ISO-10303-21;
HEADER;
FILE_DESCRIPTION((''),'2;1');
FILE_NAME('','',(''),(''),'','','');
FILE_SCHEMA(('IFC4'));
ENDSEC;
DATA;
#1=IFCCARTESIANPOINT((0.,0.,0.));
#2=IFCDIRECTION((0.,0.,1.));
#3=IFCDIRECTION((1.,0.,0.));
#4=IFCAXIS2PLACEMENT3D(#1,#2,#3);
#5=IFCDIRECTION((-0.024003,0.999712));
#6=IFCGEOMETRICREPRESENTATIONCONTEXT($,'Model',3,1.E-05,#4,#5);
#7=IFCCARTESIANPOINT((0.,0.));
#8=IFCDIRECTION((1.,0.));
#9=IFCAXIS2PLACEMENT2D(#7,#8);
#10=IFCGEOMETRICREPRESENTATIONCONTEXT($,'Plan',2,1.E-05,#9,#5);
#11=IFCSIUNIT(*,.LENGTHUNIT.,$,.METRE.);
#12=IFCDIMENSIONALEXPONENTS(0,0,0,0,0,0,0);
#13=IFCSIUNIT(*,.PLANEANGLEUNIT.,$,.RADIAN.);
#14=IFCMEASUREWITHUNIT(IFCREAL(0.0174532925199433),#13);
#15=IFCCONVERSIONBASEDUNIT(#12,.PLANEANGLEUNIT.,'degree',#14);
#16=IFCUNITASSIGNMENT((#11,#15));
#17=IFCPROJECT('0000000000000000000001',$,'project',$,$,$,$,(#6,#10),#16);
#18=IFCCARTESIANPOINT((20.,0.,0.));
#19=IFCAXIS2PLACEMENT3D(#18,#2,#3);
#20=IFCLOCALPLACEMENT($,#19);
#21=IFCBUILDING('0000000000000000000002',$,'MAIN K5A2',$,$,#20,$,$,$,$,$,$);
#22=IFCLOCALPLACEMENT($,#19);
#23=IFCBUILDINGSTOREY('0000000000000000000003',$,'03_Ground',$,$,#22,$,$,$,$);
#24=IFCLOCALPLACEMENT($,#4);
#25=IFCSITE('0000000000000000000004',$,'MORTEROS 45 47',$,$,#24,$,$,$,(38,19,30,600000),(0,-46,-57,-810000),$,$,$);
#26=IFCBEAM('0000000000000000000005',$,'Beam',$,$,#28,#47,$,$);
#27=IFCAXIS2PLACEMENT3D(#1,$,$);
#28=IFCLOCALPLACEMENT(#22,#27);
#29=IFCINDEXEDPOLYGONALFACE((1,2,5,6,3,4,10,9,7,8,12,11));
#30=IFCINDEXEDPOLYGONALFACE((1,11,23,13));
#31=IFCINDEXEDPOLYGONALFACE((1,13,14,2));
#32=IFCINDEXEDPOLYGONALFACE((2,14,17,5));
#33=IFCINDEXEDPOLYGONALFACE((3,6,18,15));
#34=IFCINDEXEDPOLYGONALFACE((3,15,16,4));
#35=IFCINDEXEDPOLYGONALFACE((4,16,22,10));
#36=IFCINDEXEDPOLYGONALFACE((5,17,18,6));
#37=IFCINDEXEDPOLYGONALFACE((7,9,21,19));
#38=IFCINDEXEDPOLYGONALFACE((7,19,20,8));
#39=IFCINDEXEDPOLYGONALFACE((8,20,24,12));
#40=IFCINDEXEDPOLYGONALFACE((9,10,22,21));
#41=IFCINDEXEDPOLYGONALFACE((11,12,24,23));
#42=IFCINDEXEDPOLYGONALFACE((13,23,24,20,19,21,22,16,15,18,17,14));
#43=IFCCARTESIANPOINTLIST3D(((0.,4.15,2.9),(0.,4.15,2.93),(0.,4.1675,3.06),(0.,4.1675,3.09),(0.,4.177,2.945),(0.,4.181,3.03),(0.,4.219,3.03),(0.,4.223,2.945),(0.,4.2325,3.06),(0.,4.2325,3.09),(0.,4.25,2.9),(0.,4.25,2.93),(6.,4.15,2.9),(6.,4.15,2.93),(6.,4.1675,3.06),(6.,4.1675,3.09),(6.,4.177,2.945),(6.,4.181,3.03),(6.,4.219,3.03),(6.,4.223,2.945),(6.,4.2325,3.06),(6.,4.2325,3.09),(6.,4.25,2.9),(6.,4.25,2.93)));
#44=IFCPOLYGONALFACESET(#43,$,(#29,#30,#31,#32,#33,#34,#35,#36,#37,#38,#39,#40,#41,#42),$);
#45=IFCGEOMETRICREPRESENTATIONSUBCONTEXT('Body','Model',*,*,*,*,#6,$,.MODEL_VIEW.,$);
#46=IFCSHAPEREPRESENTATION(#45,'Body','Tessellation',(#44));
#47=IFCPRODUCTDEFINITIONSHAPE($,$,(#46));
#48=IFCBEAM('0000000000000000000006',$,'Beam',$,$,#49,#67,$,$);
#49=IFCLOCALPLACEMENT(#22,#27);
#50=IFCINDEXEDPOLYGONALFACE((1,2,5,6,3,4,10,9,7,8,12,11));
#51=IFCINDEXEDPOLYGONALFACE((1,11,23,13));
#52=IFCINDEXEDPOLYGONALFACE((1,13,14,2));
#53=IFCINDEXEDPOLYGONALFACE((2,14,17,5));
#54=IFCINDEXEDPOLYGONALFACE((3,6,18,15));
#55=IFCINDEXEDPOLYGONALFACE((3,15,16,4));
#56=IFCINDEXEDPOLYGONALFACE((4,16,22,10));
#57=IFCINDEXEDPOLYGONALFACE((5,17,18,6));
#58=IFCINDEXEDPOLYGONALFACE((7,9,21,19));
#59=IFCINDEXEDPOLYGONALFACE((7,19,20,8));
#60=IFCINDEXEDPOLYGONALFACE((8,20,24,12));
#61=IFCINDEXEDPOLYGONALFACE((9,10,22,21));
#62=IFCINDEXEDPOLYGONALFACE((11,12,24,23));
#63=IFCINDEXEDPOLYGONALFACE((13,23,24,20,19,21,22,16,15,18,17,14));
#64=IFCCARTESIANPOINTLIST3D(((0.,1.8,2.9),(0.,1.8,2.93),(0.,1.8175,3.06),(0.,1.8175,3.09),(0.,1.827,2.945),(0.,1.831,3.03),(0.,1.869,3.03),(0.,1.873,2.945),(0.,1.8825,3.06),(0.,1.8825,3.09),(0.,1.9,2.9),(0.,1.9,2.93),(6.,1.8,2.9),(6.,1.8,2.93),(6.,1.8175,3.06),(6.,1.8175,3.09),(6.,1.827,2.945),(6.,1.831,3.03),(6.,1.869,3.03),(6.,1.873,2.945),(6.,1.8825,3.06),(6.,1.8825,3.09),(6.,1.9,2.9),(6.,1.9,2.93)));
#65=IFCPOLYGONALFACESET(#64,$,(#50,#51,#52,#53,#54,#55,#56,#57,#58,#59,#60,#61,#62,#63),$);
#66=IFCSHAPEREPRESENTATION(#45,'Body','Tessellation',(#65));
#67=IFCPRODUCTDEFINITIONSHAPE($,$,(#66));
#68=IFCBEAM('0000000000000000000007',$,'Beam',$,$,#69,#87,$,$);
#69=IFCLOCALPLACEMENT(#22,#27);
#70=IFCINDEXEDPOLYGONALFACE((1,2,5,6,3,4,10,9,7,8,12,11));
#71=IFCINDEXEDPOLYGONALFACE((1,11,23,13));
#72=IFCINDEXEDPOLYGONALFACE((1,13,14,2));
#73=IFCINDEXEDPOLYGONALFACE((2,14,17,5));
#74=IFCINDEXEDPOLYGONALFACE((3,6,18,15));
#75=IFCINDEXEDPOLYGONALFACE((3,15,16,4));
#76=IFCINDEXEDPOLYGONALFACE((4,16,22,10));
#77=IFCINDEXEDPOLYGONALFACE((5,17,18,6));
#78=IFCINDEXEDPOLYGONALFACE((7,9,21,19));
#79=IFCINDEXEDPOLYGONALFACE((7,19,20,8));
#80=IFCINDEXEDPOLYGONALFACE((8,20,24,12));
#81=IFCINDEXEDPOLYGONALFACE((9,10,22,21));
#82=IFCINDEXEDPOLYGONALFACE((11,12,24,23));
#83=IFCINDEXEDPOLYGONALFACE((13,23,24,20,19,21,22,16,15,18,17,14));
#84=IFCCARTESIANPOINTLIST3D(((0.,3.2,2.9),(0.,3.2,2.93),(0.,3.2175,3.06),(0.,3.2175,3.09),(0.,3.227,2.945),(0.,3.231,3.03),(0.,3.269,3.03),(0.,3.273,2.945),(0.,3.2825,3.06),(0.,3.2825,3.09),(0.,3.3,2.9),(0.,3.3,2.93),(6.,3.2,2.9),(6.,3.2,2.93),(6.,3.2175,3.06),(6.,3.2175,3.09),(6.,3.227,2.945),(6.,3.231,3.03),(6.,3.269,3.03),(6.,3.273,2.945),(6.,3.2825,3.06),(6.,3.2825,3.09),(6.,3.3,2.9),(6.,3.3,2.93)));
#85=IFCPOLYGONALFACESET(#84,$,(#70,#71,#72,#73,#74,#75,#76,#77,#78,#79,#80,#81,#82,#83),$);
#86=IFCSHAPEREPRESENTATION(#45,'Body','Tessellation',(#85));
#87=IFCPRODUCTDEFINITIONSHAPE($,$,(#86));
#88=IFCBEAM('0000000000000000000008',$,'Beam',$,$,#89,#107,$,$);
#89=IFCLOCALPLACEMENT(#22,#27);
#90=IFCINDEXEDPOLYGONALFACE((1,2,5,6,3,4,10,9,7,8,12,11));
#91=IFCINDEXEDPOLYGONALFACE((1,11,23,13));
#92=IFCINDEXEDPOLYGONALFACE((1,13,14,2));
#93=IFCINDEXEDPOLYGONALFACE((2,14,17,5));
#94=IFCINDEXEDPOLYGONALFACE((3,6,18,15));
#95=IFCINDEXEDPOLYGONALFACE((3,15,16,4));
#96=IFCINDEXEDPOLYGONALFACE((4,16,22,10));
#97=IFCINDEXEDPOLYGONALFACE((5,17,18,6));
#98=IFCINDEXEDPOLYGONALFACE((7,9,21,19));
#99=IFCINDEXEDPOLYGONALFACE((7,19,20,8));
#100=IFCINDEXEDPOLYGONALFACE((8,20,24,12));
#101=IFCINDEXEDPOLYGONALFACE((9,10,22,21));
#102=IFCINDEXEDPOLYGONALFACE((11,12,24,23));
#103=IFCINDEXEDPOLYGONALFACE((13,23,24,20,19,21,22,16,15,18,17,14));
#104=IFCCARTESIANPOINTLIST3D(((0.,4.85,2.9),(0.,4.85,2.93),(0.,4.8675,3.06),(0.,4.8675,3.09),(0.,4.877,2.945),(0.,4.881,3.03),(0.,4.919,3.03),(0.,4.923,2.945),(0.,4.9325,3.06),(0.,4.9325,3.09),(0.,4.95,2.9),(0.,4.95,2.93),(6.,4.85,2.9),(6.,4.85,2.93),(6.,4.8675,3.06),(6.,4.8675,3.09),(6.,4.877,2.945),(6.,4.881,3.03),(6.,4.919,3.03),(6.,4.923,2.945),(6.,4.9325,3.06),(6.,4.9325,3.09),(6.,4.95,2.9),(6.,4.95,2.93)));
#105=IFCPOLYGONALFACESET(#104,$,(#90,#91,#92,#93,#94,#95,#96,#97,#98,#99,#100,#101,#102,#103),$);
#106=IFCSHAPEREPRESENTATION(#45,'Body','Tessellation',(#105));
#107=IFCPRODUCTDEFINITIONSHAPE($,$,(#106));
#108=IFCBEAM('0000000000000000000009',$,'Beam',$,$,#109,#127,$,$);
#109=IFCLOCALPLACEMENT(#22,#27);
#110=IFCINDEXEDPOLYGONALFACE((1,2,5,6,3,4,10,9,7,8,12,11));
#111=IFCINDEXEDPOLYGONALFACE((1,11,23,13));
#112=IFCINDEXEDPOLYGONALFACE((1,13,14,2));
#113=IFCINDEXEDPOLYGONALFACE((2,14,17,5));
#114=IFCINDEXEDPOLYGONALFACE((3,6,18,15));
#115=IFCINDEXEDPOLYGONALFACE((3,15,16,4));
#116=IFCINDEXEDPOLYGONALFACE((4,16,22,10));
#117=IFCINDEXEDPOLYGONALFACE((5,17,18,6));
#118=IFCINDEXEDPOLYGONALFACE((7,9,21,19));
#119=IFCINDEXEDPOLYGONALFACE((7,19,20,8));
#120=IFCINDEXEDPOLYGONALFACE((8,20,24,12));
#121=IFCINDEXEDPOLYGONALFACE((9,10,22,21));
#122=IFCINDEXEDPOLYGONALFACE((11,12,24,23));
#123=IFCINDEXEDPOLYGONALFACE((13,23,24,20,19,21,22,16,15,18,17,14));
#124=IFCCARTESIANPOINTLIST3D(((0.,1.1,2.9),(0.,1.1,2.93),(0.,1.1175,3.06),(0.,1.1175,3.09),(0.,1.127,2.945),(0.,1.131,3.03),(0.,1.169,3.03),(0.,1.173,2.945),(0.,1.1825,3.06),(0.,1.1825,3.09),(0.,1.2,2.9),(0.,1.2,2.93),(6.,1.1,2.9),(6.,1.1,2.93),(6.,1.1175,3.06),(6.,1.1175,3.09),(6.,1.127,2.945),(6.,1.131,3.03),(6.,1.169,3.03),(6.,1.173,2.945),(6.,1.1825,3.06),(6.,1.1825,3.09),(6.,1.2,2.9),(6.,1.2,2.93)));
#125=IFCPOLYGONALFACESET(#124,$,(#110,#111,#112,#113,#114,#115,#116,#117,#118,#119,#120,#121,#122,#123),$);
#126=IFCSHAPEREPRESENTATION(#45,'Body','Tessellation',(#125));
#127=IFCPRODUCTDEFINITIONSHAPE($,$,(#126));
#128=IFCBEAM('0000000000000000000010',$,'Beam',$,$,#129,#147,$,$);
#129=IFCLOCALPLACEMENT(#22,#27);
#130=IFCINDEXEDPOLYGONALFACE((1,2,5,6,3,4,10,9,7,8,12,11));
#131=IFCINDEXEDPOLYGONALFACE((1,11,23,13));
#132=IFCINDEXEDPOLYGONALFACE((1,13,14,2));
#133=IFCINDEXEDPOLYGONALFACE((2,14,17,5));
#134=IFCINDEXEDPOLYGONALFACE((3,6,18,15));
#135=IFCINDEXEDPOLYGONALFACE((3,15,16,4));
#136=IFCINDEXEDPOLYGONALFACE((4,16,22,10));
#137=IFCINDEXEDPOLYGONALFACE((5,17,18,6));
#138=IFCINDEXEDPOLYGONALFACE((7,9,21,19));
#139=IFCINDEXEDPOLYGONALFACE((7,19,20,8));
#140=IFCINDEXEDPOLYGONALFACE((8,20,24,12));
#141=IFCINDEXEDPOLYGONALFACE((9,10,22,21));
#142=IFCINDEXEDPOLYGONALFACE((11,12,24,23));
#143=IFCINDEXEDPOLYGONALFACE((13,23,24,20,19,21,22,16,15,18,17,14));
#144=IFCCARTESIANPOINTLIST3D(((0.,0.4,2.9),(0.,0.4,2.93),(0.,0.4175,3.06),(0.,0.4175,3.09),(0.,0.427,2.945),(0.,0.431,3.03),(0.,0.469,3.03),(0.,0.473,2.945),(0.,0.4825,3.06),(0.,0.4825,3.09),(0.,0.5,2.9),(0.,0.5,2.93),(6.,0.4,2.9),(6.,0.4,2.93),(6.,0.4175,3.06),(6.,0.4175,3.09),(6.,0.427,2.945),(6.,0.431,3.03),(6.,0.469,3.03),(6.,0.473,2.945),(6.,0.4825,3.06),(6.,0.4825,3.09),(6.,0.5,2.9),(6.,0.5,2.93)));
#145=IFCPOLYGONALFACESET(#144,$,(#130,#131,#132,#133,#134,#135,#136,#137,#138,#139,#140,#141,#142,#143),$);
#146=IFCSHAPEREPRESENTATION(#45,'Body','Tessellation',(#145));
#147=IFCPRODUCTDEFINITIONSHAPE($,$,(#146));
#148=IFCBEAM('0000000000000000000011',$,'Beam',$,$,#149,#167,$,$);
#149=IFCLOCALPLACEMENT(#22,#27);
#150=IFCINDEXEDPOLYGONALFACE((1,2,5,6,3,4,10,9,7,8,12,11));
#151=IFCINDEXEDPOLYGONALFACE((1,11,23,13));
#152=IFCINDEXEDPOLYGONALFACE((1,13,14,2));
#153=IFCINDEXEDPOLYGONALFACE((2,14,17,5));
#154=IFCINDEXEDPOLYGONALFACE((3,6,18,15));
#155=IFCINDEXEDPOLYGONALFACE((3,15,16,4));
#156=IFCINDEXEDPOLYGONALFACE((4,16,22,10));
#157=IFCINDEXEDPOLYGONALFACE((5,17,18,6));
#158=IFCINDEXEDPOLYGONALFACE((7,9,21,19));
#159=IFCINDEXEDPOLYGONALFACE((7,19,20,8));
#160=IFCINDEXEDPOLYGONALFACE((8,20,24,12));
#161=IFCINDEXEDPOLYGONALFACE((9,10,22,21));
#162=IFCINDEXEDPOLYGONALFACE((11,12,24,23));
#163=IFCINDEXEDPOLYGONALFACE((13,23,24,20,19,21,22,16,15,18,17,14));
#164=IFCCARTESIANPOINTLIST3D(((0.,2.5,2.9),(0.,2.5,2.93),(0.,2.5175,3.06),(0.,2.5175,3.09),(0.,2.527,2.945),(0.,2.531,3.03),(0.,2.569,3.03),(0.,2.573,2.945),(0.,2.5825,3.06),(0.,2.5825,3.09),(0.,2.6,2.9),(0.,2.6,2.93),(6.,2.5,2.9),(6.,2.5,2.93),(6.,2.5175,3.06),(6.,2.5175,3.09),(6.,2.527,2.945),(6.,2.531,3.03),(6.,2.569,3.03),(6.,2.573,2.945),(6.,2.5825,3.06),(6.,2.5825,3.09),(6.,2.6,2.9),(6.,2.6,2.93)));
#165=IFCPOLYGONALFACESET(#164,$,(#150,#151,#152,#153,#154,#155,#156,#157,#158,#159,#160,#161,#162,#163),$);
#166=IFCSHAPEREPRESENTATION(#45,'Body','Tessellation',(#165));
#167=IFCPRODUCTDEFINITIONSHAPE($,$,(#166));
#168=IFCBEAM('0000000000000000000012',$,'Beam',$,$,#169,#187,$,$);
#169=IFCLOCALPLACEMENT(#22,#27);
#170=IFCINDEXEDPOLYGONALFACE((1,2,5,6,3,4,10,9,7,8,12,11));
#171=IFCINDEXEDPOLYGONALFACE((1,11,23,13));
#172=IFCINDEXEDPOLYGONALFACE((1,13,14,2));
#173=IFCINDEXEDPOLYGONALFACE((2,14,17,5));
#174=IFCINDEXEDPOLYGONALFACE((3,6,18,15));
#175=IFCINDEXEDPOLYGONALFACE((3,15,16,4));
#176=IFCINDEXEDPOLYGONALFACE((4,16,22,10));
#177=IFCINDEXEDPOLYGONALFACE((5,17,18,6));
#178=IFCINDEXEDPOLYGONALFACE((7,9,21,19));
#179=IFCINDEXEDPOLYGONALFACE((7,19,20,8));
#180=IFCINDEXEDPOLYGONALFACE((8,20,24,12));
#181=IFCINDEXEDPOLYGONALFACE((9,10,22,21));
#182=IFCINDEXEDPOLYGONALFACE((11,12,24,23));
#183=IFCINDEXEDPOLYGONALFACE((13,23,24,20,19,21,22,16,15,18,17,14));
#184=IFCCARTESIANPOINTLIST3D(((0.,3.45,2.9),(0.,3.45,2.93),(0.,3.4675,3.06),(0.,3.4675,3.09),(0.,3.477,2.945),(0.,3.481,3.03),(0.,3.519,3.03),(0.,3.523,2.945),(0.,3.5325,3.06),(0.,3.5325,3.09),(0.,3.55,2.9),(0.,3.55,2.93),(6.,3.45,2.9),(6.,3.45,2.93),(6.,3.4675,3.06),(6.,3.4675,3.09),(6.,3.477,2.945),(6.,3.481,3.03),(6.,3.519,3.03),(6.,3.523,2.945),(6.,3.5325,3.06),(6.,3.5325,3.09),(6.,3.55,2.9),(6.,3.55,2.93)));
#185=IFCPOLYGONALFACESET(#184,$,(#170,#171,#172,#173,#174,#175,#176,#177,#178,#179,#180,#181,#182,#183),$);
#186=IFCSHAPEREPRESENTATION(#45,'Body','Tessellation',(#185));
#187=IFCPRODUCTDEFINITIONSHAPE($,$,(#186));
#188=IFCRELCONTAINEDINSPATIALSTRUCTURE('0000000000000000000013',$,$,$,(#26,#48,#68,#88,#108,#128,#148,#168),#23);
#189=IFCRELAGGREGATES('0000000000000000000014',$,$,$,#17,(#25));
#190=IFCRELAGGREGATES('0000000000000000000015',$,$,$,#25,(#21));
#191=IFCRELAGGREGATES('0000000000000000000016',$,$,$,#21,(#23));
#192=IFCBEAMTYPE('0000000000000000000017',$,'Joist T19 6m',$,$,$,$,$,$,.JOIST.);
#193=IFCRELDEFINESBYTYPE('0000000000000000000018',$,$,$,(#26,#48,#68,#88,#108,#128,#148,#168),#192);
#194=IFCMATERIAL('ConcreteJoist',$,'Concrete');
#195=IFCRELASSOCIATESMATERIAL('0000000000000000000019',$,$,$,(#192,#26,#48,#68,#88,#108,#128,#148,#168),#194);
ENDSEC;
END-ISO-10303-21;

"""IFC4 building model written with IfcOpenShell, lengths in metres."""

from ifc_helpers import new_model, entity, si_unit, converted_unit, direction, frame, origin_with_axes, origin_2d_with_axis, place, context, subcontext, project, spatial, indexed_curve, outline, extrude, material, material_profile, profile_set, profile_usage, type_object, element, save


model = new_model("IFC4")

# Units and contexts
model_context = context("Model", 3, precision=1e-05, world=origin_with_axes(), true_north=direction((-0.024003, 0.999712)))
plan_context = context("Plan", 2, precision=1e-05, world=origin_2d_with_axis(), true_north=direction((-0.024003, 0.999712)))
body_context_1 = subcontext(model_context, "Body", "Model", "MODEL_VIEW")
ifc_project = project(units=[si_unit("LENGTHUNIT", "METRE"), converted_unit("PLANEANGLEUNIT", "degree", entity("IfcReal", 0.0174532925199433), si_unit("PLANEANGLEUNIT", "RADIAN"), dimensions=[0, 0, 0, 0, 0, 0, 0])], contexts=[model_context, plan_context])

# Site, building, storey
site_placement = place(None, origin_with_axes())
site = spatial("IfcSite", under=ifc_project, at=site_placement, Name="MORTEROS 45 47", RefLatitude=(38, 19, 30, 600000), RefLongitude=(0, -46, -57, -810000))
building_placement = place(None, frame((20.0, 0.0, 0.0), z_axis=(0.0, 0.0, 1.0), x_axis=(1.0, 0.0, 0.0)))
building = spatial("IfcBuilding", under=site, at=building_placement, Name="MAIN K5A2")
storey_placement = place(None, frame((20.0, 0.0, 0.0), z_axis=(0.0, 0.0, 1.0), x_axis=(1.0, 0.0, 0.0)))
storey = spatial("IfcBuildingStorey", under=building, at=storey_placement, Name="03_Ground")

# Beams
ifc_material = material(Name="ConcreteJoist", Category="Concrete")
ifc_material_profile = material_profile(ifc_material, outline(indexed_curve([(0.019, 0.13), (0.023, 0.045), (0.05, 0.03), (0.05, 0.0), (-0.05, 0.0), (-0.05, 0.03), (-0.023, 0.045), (-0.019, 0.13), (-0.0325, 0.16), (-0.0325, 0.19), (0.0325, 0.19), (0.0325, 0.16), (0.019, 0.13)])))
ifc_profile_set = profile_set([ifc_material_profile], Name="JoistmaterialProfile")
ifc_profile_usage_1 = profile_usage(ifc_profile_set)
beam_type = type_object("IfcBeamType", Name="Joist T19 6m", PredefinedType="JOIST", material=ifc_profile_set)
beam_1_placement = place(None, frame((20.0, 4.2, 2.9), z_axis=(1.0, 0.0, 0.0), x_axis=(0.0, 1.0, 0.0)))
element("IfcBeam", 1, at=beam_1_placement, inside=storey, type_object=beam_type, material=ifc_profile_usage_1, Name="Beam", context=body_context_1, shape_type="SweptSolid", body=[
    extrude(outline(indexed_curve([(0.019, 0.13), (0.023, 0.045), (0.05, 0.03), (0.05, 0.0), (-0.05, 0.0), (-0.05, 0.03), (-0.023, 0.045), (-0.019, 0.13), (-0.0325, 0.16), (-0.0325, 0.19), (0.0325, 0.19), (0.0325, 0.16), (0.019, 0.13)])), origin_with_axes(), (0.0, 0.0, 1.0), 6.0),
])
ifc_profile_usage_2 = profile_usage(ifc_profile_set)
beam_2_placement = place(None, frame((20.0, 1.85, 2.9), z_axis=(1.0, 0.0, 0.0), x_axis=(0.0, 1.0, 0.0)))
element("IfcBeam", 2, at=beam_2_placement, inside=storey, type_object=beam_type, material=ifc_profile_usage_2, Name="Beam", context=body_context_1, shape_type="SweptSolid", body=[
    extrude(outline(indexed_curve([(0.019, 0.13), (0.023, 0.045), (0.05, 0.03), (0.05, 0.0), (-0.05, 0.0), (-0.05, 0.03), (-0.023, 0.045), (-0.019, 0.13), (-0.0325, 0.16), (-0.0325, 0.19), (0.0325, 0.19), (0.0325, 0.16), (0.019, 0.13)])), origin_with_axes(), (0.0, 0.0, 1.0), 6.0),
])
ifc_profile_usage_3 = profile_usage(ifc_profile_set)
beam_3_placement = place(None, frame((20.0, 3.25, 2.9), z_axis=(1.0, 0.0, 0.0), x_axis=(0.0, 1.0, 0.0)))
element("IfcBeam", 3, at=beam_3_placement, inside=storey, type_object=beam_type, material=ifc_profile_usage_3, Name="Beam", context=body_context_1, shape_type="SweptSolid", body=[
    extrude(outline(indexed_curve([(0.019, 0.13), (0.023, 0.045), (0.05, 0.03), (0.05, 0.0), (-0.05, 0.0), (-0.05, 0.03), (-0.023, 0.045), (-0.019, 0.13), (-0.0325, 0.16), (-0.0325, 0.19), (0.0325, 0.19), (0.0325, 0.16), (0.019, 0.13)])), origin_with_axes(), (0.0, 0.0, 1.0), 6.0),
])
ifc_profile_usage_4 = profile_usage(ifc_profile_set)
beam_4_placement = place(None, frame((20.0, 4.9, 2.9), z_axis=(1.0, 0.0, 0.0), x_axis=(0.0, 1.0, 0.0)))
element("IfcBeam", 4, at=beam_4_placement, inside=storey, type_object=beam_type, material=ifc_profile_usage_4, Name="Beam", context=body_context_1, shape_type="SweptSolid", body=[
    extrude(outline(indexed_curve([(0.019, 0.13), (0.023, 0.045), (0.05, 0.03), (0.05, 0.0), (-0.05, 0.0), (-0.05, 0.03), (-0.023, 0.045), (-0.019, 0.13), (-0.0325, 0.16), (-0.0325, 0.19), (0.0325, 0.19), (0.0325, 0.16), (0.019, 0.13)])), origin_with_axes(), (0.0, 0.0, 1.0), 6.0),
])
ifc_profile_usage_5 = profile_usage(ifc_profile_set)
beam_5_placement = place(None, frame((20.0, 1.15, 2.9), z_axis=(1.0, 0.0, 0.0), x_axis=(0.0, 1.0, 0.0)))
element("IfcBeam", 5, at=beam_5_placement, inside=storey, type_object=beam_type, material=ifc_profile_usage_5, Name="Beam", context=body_context_1, shape_type="SweptSolid", body=[
    extrude(outline(indexed_curve([(0.019, 0.13), (0.023, 0.045), (0.05, 0.03), (0.05, 0.0), (-0.05, 0.0), (-0.05, 0.03), (-0.023, 0.045), (-0.019, 0.13), (-0.0325, 0.16), (-0.0325, 0.19), (0.0325, 0.19), (0.0325, 0.16), (0.019, 0.13)])), origin_with_axes(), (0.0, 0.0, 1.0), 6.0),
])
ifc_profile_usage_6 = profile_usage(ifc_profile_set)
beam_6_placement = place(None, frame((20.0, 0.45, 2.9), z_axis=(1.0, 0.0, 0.0), x_axis=(0.0, 1.0, 0.0)))
element("IfcBeam", 6, at=beam_6_placement, inside=storey, type_object=beam_type, material=ifc_profile_usage_6, Name="Beam", context=body_context_1, shape_type="SweptSolid", body=[
    extrude(outline(indexed_curve([(0.019, 0.13), (0.023, 0.045), (0.05, 0.03), (0.05, 0.0), (-0.05, 0.0), (-0.05, 0.03), (-0.023, 0.045), (-0.019, 0.13), (-0.0325, 0.16), (-0.0325, 0.19), (0.0325, 0.19), (0.0325, 0.16), (0.019, 0.13)])), origin_with_axes(), (0.0, 0.0, 1.0), 6.0),
])
ifc_profile_usage_7 = profile_usage(ifc_profile_set)
beam_7_placement = place(None, frame((20.0, 2.55, 2.9), z_axis=(1.0, 0.0, 0.0), x_axis=(0.0, 1.0, 0.0)))
element("IfcBeam", 7, at=beam_7_placement, inside=storey, type_object=beam_type, material=ifc_profile_usage_7, Name="Beam", context=body_context_1, shape_type="SweptSolid", body=[
    extrude(outline(indexed_curve([(0.019, 0.13), (0.023, 0.045), (0.05, 0.03), (0.05, 0.0), (-0.05, 0.0), (-0.05, 0.03), (-0.023, 0.045), (-0.019, 0.13), (-0.0325, 0.16), (-0.0325, 0.19), (0.0325, 0.19), (0.0325, 0.16), (0.019, 0.13)])), origin_with_axes(), (0.0, 0.0, 1.0), 6.0),
])
ifc_profile_usage_8 = profile_usage(ifc_profile_set)
beam_8_placement = place(None, frame((20.0, 3.5, 2.9), z_axis=(1.0, 0.0, 0.0), x_axis=(0.0, 1.0, 0.0)))
element("IfcBeam", 8, at=beam_8_placement, inside=storey, type_object=beam_type, material=ifc_profile_usage_8, Name="Beam", context=body_context_1, shape_type="SweptSolid", body=[
    extrude(outline(indexed_curve([(0.019, 0.13), (0.023, 0.045), (0.05, 0.03), (0.05, 0.0), (-0.05, 0.0), (-0.05, 0.03), (-0.023, 0.045), (-0.019, 0.13), (-0.0325, 0.16), (-0.0325, 0.19), (0.0325, 0.19), (0.0325, 0.16), (0.019, 0.13)])), origin_with_axes(), (0.0, 0.0, 1.0), 6.0),
])

save(model, "model.ifc")
